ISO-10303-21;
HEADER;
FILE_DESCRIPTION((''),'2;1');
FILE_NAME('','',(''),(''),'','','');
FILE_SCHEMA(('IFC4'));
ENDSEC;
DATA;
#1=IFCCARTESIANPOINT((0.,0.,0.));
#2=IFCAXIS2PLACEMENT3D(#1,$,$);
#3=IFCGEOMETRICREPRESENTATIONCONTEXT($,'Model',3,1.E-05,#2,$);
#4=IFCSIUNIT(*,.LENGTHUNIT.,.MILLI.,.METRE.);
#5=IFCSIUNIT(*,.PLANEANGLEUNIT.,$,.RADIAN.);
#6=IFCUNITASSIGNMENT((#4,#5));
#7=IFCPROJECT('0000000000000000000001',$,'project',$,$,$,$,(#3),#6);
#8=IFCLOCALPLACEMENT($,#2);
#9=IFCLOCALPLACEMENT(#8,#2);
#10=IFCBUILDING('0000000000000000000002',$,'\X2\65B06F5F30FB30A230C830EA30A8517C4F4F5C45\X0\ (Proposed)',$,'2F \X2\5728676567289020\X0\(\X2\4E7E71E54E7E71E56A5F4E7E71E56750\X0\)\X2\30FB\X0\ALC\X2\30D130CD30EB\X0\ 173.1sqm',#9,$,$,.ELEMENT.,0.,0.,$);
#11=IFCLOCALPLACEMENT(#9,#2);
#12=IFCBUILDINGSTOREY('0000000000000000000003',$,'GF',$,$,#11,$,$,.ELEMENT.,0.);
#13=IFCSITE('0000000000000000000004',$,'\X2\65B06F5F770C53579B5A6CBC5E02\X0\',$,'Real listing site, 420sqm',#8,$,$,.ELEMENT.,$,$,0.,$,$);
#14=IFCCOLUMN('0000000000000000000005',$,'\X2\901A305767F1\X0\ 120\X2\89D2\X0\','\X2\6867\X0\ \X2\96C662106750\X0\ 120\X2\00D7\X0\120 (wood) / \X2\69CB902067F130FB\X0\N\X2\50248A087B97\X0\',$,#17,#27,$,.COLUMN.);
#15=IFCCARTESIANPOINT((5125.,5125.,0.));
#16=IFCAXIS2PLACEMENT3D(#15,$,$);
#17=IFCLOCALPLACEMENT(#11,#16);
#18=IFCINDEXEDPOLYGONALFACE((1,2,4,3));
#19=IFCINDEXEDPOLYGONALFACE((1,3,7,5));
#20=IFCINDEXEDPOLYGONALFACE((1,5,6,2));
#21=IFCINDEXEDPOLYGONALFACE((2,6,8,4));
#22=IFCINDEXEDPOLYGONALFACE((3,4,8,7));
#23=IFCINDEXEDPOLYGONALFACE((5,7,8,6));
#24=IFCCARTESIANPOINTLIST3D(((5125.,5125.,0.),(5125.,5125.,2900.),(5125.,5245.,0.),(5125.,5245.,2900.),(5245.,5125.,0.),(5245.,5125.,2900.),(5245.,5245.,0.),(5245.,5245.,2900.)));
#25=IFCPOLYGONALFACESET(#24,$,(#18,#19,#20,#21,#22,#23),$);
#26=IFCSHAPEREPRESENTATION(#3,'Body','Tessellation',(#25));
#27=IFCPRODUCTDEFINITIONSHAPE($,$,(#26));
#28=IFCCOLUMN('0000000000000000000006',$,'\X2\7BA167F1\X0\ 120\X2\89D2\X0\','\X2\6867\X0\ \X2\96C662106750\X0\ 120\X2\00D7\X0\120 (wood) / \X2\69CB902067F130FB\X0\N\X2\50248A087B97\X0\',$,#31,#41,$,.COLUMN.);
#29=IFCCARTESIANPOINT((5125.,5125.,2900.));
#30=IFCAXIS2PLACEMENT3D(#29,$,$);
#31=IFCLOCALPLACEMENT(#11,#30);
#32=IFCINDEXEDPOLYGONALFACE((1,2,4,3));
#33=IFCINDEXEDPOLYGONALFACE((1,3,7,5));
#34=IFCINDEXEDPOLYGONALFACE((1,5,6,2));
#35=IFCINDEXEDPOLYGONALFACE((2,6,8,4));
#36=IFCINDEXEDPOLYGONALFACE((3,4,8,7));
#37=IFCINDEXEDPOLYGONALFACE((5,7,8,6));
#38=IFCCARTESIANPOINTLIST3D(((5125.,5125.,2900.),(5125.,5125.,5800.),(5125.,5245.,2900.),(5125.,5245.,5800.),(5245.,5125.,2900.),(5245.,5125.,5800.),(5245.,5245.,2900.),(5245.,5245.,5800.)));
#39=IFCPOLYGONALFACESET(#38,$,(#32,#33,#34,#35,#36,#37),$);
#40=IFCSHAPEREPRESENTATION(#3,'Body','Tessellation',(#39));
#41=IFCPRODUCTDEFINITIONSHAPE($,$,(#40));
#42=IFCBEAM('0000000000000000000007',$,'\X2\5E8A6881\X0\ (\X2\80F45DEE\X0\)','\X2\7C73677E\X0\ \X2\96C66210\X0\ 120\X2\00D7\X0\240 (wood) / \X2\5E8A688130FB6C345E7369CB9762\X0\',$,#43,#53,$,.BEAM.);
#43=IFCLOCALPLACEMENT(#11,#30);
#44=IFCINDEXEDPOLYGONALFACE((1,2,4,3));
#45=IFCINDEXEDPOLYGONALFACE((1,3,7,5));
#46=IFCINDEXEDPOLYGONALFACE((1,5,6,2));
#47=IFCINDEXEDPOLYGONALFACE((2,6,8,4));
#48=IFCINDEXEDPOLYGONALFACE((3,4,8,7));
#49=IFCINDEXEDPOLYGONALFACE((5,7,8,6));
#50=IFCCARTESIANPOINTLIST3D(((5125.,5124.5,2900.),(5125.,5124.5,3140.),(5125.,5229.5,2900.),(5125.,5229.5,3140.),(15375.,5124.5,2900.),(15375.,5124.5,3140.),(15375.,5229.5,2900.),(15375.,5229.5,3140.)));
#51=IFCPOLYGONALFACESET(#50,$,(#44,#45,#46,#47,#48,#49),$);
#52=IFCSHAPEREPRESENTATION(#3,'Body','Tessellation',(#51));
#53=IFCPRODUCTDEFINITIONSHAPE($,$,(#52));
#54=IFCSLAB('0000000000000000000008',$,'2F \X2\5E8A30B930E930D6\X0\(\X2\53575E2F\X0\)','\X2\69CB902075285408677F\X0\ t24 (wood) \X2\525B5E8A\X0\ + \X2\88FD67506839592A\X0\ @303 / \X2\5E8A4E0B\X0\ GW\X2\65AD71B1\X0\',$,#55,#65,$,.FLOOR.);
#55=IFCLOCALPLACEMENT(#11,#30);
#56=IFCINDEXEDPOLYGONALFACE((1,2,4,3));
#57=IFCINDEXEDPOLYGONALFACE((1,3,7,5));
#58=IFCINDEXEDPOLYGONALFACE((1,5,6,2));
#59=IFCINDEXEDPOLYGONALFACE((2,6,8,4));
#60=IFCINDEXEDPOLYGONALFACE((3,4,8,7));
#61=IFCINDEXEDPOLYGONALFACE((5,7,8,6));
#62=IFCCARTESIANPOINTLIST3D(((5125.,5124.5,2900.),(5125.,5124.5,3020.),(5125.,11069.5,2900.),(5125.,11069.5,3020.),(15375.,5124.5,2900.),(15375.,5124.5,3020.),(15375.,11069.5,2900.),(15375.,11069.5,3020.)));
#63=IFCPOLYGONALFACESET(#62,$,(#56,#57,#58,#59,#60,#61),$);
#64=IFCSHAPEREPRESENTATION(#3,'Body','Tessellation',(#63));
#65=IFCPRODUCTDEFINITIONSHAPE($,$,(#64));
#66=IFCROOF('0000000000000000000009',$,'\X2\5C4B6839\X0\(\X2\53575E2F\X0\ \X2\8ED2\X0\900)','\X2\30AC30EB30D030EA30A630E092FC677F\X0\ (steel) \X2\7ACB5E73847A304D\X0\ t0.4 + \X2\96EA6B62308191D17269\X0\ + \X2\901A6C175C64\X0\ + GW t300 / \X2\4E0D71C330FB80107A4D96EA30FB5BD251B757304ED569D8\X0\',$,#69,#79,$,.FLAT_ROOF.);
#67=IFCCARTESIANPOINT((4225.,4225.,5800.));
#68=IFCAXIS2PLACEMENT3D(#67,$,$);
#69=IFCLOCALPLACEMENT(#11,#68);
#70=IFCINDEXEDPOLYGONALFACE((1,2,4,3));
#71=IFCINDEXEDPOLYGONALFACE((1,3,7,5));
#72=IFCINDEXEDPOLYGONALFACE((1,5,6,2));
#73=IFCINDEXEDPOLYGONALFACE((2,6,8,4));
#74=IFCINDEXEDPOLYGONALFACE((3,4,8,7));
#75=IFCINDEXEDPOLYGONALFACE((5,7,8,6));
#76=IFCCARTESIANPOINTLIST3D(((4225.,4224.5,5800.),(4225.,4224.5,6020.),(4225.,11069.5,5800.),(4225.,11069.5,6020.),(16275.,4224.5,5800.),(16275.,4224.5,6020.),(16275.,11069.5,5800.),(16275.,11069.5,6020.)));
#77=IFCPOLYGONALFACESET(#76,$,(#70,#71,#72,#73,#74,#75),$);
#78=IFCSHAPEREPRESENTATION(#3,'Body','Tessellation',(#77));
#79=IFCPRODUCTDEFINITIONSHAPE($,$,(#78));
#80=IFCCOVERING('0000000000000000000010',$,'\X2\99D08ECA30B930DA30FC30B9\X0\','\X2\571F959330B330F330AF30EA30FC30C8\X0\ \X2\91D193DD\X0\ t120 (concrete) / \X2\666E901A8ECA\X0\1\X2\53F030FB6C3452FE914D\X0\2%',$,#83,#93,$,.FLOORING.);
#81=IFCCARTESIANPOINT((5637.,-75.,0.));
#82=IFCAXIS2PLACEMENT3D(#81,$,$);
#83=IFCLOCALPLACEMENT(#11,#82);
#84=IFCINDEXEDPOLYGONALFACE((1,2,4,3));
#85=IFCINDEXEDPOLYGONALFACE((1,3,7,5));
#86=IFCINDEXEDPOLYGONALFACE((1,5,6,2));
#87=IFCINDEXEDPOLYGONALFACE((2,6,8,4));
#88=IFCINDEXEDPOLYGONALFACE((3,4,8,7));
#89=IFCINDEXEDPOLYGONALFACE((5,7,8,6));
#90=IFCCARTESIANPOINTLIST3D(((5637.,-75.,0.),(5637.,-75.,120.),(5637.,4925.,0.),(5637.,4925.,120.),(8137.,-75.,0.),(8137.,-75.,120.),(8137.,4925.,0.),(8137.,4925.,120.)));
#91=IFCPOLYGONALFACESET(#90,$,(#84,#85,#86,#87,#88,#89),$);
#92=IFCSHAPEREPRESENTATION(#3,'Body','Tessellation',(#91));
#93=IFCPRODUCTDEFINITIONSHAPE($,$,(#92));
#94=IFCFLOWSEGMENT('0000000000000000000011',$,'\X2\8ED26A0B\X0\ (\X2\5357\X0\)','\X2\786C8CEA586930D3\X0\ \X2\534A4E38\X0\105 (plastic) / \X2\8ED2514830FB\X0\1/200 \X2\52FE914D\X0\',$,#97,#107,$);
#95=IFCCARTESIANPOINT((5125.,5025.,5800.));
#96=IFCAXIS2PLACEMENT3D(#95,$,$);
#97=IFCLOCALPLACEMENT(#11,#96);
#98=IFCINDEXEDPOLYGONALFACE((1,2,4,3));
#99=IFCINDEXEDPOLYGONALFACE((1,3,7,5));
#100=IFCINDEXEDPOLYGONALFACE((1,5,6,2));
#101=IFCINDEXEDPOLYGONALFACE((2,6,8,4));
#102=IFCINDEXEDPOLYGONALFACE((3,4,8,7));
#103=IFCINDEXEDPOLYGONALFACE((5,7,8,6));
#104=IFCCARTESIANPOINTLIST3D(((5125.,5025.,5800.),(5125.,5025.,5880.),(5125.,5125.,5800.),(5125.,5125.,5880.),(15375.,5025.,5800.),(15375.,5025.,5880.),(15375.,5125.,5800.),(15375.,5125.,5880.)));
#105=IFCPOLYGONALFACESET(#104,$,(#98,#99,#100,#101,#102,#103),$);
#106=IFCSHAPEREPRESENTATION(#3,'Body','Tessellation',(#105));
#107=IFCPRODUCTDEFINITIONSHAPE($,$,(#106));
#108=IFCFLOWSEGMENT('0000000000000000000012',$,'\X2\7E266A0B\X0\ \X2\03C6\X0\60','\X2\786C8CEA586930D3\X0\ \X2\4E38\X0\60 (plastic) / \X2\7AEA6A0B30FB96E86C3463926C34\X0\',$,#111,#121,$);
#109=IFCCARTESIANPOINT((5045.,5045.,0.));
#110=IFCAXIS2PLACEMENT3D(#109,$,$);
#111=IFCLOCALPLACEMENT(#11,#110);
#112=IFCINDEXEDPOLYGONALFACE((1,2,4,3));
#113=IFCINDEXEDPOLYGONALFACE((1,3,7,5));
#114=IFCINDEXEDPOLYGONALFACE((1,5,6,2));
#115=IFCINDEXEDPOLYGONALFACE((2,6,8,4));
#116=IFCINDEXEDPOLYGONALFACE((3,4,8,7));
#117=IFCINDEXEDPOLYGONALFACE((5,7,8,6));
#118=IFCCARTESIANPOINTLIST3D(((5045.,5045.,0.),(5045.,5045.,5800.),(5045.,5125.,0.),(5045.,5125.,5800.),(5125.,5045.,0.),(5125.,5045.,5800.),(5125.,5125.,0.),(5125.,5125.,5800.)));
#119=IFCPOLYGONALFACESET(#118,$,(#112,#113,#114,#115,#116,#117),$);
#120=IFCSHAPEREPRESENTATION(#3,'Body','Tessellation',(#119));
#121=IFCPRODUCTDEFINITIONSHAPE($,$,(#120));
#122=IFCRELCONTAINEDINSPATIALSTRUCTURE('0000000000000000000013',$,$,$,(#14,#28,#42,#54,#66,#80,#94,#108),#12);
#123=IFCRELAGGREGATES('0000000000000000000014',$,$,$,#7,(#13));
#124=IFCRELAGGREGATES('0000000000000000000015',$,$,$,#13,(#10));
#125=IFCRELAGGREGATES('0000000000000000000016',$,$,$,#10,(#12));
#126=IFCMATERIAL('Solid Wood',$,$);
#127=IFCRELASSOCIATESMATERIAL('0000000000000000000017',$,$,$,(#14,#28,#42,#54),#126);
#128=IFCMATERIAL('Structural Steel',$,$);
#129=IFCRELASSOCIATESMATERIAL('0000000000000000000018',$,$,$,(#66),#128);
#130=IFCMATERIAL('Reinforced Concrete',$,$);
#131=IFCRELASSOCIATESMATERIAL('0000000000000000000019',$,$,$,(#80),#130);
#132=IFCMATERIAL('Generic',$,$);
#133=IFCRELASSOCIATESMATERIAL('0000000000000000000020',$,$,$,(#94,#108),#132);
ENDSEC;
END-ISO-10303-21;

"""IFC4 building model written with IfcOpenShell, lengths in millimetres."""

from ifc_helpers import new_model, si_unit, frame, frame_2d, origin, place, context, project, spatial, rectangle, extrude, material, element, save


model = new_model("IFC4")

# Units and contexts
model_context = context("Model", 3, precision=1e-05, world=origin())
ifc_project = project(units=[si_unit("LENGTHUNIT", "METRE", prefix="MILLI"), si_unit("PLANEANGLEUNIT", "RADIAN")], contexts=[model_context])

# Site, building, storey
site_placement = place(None, origin())
site = spatial("IfcSite", under=ifc_project, at=site_placement, Name="新潟県南魚沼市", ObjectType="Real listing site, 420sqm", CompositionType="ELEMENT", RefElevation=0.0)
building_placement = place(site_placement, origin())
building = spatial("IfcBuilding", under=site, at=building_placement, Name="新潟・アトリエ兼住居 (Proposed)", ObjectType="2F 在来木造(乾燥乾燥機乾燥材)・ALCパネル 173.1sqm", CompositionType="ELEMENT", ElevationOfRefHeight=0.0, ElevationOfTerrain=0.0)
storey_placement = place(building_placement, origin())
storey = spatial("IfcBuildingStorey", under=building, at=storey_placement, Name="GF", CompositionType="ELEMENT", Elevation=0.0)

# Columns
ifc_material_1 = material(Name="Solid Wood")
column_1_placement = place(storey_placement, frame((5125.0, 5125.0, 0.0)))
element("IfcColumn", 1, at=column_1_placement, inside=storey, material=ifc_material_1, Name="通し柱 120角", Description="桧 集成材 120×120 (wood) / 構造柱・N値計算", PredefinedType="COLUMN", context=model_context, shape_type="SweptSolid", body=[
    extrude(rectangle(XDim=120.0, YDim=120.0, at=frame_2d((60.0, 60.0))), frame((5125.0, 5125.0, 0.0)), (0.0, 0.0, 1.0), 2900.0),
])
column_2_placement = place(storey_placement, frame((5125.0, 5125.0, 2900.0)))
element("IfcColumn", 2, at=column_2_placement, inside=storey, material=ifc_material_1, Name="管柱 120角", Description="桧 集成材 120×120 (wood) / 構造柱・N値計算", PredefinedType="COLUMN", context=model_context, shape_type="SweptSolid", body=[
    extrude(rectangle(XDim=120.0, YDim=120.0, at=frame_2d((60.0, 60.0))), frame((5125.0, 5125.0, 2900.0)), (0.0, 0.0, 1.0), 2900.0),
])

# Beam
beam_1_placement = place(storey_placement, frame((5125.0, 5125.0, 2900.0)))
element("IfcBeam", 3, at=beam_1_placement, inside=storey, material=ifc_material_1, Name="床梁 (胴差)", Description="米松 集成 120×240 (wood) / 床梁・水平構面", PredefinedType="BEAM", context=model_context, shape_type="SweptSolid", body=[
    extrude(rectangle(XDim=10250.0, YDim=105.0, at=frame_2d((5125.0, 52.0))), frame((5125.0, 5125.0, 2900.0)), (0.0, 0.0, 1.0), 240.0),
])

# Slab
ifc_material_2 = material(Name="Reinforced Concrete")
slab_1_placement = place(storey_placement, frame((5125.0, 5125.0, 2900.0)))
element("IfcSlab", 4, at=slab_1_placement, inside=storey, material=ifc_material_1, Name="2F 床スラブ(南帯)", Description="構造用合板 t24 (wood) 剛床 + 製材根太 @303 / 床下 GW断熱", PredefinedType="FLOOR", context=model_context, shape_type="SweptSolid", body=[
    extrude(rectangle(XDim=10250.0, YDim=5945.0, at=frame_2d((5125.0, 2972.0))), frame((5125.0, 5125.0, 2900.0)), (0.0, 0.0, 1.0), 120.0),
])

# Roof
ifc_material_3 = material(Name="Structural Steel")
for number, where, name in (
    (5, (4225.0, 4225.0, 5800.0), "屋根(南帯 軒900)"),
):
    element("IfcRoof", number, at=place(storey_placement, frame(where)), inside=storey, material=ifc_material_3, Name=name, Description="ガルバリウム鋼板 (steel) 立平葺き t0.4 + 雪止め金物 + 通気層 + GW t300 / 不燃・耐積雪・寒冷地仕様", PredefinedType="FLAT_ROOF", context=model_context, shape_type="SweptSolid", body=[
        extrude(rectangle(XDim=12050.0, YDim=6845.0, at=frame_2d((6025.0, 3422.0))), frame((4225.0, 4225.0, 5800.0)), (0.0, 0.0, 1.0), 220.0),
    ])

# Covering
covering_placement = place(storey_placement, frame((5637.0, -75.0, 0.0)))
element("IfcCovering", 6, at=covering_placement, inside=storey, material=ifc_material_2, Name="駐車スペース", Description="土間コンクリート 金鏝 t120 (concrete) / 普通車1台・水勾配2%", PredefinedType="FLOORING", context=model_context, shape_type="SweptSolid", body=[
    extrude(rectangle(XDim=2500.0, YDim=5000.0, at=frame_2d((1250.0, 2500.0))), frame((5637.0, -75.0, 0.0)), (0.0, 0.0, 1.0), 120.0),
])

# Flow segments
ifc_material_4 = material(Name="Generic")
flow_segment_1_placement = place(storey_placement, frame((5125.0, 5025.0, 5800.0)))
element("IfcFlowSegment", 7, at=flow_segment_1_placement, inside=storey, material=ifc_material_4, Name="軒樋 (南)", Description="硬質塩ビ 半丸105 (plastic) / 軒先・1/200 勾配", context=model_context, shape_type="SweptSolid", body=[
    extrude(rectangle(XDim=10250.0, YDim=100.0, at=frame_2d((5125.0, 50.0))), frame((5125.0, 5025.0, 5800.0)), (0.0, 0.0, 1.0), 80.0),
])
flow_segment_2_placement = place(storey_placement, frame((5045.0, 5045.0, 0.0)))
element("IfcFlowSegment", 8, at=flow_segment_2_placement, inside=storey, material=ifc_material_4, Name="縦樋 φ60", Description="硬質塩ビ 丸60 (plastic) / 竪樋・雨水排水", context=model_context, shape_type="SweptSolid", body=[
    extrude(rectangle(XDim=80.0, YDim=80.0, at=frame_2d((40.0, 40.0))), frame((5045.0, 5045.0, 0.0)), (0.0, 0.0, 1.0), 5800.0),
])

save(model, "model.ifc")
